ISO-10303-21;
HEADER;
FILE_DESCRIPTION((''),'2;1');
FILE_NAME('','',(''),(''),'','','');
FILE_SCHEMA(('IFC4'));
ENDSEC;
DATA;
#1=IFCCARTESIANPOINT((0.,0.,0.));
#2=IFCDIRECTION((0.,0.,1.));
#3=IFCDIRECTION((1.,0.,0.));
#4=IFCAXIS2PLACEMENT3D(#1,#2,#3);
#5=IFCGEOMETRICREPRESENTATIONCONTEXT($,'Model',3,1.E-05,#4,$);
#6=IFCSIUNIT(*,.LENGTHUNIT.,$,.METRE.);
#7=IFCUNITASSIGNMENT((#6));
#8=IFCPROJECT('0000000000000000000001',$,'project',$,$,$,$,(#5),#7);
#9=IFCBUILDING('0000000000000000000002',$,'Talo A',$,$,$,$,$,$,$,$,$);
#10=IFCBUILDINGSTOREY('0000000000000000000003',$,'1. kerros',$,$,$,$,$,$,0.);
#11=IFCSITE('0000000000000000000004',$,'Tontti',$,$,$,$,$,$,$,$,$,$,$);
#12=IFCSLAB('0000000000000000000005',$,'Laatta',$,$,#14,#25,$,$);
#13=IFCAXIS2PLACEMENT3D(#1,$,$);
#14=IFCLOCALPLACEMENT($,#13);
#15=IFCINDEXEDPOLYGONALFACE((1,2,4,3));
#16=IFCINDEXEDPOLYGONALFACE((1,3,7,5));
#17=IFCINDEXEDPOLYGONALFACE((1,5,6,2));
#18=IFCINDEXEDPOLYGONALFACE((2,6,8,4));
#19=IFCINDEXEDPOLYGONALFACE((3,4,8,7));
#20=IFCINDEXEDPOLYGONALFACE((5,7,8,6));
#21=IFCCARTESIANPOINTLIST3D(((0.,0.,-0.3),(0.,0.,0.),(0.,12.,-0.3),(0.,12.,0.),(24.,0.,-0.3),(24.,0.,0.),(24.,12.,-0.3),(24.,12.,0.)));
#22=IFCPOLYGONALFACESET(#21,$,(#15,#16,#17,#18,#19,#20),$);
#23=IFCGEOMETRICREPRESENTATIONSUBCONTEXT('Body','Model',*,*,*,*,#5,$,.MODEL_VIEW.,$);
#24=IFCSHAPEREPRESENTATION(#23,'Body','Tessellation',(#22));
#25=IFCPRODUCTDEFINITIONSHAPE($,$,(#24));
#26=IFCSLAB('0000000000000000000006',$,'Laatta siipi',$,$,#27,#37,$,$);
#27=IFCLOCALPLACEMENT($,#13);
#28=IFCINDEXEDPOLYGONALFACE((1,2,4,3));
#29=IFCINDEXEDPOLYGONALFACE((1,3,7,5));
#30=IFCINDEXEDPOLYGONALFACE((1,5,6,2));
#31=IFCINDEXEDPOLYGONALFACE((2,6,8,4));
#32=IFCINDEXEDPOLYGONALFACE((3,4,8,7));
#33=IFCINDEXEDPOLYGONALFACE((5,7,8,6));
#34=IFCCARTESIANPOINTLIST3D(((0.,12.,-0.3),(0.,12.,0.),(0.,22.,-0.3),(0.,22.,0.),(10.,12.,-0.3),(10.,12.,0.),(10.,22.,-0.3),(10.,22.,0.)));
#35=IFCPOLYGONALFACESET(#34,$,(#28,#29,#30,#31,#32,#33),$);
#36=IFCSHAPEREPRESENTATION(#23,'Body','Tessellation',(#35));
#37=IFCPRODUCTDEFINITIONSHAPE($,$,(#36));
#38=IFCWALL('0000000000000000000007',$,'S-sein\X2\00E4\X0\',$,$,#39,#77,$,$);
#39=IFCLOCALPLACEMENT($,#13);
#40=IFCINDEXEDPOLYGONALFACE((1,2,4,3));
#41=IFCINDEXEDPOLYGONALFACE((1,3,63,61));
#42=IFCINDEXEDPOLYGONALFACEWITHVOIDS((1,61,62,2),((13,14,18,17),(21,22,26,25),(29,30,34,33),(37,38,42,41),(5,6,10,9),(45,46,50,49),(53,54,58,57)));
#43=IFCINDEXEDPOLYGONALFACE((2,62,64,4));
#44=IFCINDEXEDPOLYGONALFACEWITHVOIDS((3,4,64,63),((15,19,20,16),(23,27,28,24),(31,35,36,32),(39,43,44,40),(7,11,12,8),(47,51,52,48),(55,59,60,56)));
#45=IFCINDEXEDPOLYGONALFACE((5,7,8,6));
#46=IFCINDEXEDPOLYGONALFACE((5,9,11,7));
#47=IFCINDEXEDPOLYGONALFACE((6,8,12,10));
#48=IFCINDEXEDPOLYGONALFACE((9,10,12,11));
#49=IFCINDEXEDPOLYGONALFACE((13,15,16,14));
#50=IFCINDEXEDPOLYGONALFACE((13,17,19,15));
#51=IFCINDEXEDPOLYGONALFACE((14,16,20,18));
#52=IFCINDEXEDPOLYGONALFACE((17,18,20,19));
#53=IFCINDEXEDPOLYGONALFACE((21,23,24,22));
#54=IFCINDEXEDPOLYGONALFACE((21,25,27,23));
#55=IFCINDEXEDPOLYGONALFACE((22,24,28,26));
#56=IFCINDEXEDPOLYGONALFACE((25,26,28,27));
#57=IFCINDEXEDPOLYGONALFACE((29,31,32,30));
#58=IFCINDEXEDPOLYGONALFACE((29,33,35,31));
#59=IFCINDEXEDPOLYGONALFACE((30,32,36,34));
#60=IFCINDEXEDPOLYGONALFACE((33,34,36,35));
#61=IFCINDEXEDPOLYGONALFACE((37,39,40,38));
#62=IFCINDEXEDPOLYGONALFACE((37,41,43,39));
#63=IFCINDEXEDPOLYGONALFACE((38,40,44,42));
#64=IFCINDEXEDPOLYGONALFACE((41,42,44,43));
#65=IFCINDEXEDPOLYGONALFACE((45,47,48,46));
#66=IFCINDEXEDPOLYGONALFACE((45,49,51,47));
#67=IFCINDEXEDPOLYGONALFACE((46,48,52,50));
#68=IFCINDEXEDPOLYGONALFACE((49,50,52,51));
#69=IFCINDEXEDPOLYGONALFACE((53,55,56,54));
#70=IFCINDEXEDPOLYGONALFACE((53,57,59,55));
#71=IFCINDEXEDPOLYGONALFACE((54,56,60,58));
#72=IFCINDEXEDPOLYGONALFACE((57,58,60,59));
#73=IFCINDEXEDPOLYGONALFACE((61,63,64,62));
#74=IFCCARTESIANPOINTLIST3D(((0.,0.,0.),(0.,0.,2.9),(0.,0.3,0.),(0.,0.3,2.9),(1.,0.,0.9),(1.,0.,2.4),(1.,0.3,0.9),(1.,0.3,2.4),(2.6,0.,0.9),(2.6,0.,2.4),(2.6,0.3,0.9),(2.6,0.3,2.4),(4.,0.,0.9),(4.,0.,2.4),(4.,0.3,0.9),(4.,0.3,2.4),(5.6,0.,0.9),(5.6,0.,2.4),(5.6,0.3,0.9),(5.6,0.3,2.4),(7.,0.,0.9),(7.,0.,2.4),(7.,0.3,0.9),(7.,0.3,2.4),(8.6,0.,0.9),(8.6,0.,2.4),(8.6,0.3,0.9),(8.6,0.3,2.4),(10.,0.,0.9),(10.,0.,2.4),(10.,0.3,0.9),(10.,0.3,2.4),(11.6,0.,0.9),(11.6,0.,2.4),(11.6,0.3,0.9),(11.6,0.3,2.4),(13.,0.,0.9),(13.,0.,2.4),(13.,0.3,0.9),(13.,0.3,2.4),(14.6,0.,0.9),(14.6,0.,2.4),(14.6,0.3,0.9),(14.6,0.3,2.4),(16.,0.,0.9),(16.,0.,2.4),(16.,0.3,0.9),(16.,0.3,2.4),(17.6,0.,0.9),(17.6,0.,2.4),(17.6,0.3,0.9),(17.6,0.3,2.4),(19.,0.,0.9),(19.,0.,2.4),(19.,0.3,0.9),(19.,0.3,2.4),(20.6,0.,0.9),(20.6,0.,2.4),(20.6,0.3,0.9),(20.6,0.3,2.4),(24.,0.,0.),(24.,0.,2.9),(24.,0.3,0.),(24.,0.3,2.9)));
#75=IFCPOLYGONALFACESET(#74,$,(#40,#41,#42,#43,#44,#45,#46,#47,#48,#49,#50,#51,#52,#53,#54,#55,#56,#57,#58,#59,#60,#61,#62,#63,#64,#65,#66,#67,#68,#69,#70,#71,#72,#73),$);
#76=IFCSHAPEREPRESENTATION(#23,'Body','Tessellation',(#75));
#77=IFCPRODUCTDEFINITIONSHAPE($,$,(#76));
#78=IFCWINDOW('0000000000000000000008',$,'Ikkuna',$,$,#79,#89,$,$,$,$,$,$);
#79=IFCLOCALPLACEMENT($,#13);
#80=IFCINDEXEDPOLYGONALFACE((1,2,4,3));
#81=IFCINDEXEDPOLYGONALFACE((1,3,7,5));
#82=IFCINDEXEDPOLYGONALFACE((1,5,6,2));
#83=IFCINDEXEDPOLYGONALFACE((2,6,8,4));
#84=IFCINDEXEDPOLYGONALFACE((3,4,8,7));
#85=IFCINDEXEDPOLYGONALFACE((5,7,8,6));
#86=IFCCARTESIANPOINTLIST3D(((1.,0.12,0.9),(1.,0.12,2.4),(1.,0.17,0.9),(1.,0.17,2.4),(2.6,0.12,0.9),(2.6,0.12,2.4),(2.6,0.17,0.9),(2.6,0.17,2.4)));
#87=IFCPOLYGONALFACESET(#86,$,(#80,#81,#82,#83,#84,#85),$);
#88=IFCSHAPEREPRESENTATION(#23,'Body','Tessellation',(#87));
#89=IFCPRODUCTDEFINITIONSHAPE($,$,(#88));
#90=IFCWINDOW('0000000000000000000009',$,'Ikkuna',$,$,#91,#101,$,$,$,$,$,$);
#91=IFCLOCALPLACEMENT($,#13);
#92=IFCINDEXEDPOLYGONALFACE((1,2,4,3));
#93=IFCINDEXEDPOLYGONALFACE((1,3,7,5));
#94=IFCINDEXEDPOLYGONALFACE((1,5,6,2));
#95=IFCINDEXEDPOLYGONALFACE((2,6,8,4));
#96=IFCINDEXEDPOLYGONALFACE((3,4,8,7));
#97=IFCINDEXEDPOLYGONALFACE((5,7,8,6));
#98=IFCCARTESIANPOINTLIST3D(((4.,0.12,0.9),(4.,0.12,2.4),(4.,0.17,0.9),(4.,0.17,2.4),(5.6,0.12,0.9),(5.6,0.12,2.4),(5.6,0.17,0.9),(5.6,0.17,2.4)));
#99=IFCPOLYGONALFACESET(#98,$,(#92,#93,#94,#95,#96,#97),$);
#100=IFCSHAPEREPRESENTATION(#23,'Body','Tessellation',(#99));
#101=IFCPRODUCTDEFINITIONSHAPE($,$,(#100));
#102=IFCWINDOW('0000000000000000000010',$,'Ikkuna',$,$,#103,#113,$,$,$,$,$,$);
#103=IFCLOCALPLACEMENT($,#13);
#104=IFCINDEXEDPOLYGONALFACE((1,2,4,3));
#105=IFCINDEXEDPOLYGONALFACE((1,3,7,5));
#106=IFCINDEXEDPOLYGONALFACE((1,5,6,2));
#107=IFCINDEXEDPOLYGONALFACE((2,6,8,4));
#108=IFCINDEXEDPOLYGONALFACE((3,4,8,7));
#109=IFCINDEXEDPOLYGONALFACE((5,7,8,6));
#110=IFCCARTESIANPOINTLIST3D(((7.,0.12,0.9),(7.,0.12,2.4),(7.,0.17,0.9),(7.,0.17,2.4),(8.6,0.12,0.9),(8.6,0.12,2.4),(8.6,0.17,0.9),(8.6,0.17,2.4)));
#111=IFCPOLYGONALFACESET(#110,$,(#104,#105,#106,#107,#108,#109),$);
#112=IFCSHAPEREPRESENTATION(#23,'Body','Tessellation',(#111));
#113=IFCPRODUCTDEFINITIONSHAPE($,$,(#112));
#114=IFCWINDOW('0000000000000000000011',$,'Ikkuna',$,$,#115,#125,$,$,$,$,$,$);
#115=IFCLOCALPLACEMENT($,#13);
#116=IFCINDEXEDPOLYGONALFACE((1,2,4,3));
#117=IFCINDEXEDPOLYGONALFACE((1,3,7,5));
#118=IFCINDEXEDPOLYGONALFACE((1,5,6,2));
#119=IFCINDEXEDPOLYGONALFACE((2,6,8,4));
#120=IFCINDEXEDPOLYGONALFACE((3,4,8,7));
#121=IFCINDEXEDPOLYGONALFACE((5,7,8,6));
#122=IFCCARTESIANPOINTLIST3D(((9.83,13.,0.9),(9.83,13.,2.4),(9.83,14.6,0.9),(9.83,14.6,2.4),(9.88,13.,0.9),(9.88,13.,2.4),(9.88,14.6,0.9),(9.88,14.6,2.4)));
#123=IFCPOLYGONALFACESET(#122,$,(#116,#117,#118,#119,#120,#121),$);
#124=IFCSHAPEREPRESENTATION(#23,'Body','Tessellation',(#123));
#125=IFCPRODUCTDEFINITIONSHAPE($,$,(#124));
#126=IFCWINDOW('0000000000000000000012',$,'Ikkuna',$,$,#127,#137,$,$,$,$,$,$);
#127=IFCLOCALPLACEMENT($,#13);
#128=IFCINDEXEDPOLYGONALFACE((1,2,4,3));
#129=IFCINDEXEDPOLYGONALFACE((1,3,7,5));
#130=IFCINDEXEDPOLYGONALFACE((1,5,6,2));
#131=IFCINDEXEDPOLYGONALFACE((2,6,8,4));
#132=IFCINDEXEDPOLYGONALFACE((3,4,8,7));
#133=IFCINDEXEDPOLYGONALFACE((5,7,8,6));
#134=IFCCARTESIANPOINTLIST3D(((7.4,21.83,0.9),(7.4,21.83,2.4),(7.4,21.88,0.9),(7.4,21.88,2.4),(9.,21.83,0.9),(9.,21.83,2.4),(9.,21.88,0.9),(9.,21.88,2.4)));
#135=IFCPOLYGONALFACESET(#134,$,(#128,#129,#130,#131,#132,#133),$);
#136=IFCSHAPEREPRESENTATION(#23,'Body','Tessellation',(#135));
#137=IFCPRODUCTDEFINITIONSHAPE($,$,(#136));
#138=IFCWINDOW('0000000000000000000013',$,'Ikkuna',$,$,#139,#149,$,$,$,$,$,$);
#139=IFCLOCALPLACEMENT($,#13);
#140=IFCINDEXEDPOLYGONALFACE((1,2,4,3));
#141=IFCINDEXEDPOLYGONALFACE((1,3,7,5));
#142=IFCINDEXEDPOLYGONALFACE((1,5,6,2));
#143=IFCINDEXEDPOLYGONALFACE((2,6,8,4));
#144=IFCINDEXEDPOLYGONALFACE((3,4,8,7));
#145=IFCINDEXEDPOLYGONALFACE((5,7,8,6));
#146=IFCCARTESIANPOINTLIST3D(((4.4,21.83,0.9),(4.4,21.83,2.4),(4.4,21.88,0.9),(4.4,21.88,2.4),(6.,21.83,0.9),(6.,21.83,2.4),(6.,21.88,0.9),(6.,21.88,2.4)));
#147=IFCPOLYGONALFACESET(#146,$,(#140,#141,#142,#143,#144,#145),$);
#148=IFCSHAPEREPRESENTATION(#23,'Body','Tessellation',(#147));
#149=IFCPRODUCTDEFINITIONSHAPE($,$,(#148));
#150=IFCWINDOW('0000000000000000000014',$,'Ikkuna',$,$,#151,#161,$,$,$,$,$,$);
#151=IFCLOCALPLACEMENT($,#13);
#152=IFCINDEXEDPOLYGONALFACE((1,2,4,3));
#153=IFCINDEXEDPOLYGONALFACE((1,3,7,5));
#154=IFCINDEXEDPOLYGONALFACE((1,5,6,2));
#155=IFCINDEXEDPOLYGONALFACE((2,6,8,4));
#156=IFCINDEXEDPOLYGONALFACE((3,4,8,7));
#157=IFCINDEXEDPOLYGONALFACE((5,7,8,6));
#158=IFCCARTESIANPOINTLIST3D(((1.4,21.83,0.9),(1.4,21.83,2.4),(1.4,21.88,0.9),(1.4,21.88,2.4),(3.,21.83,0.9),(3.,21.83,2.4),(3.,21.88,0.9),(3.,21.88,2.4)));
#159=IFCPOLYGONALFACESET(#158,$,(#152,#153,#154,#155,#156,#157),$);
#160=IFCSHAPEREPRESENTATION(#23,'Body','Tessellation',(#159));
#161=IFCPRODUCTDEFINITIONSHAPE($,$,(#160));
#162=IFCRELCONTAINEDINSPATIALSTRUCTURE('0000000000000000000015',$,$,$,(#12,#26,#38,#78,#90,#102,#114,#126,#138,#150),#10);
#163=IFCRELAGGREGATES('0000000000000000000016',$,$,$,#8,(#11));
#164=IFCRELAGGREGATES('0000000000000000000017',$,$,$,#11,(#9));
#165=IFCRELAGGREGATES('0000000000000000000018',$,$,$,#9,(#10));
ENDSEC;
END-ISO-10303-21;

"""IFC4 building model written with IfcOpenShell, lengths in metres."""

from ifc_helpers import new_model, si_unit, frame, origin_with_axes, place, context, subcontext, project, spatial, indexed_curve, outline, extrude, element, save


model = new_model("IFC4")

# Units and contexts
model_context = context("Model", 3, precision=1e-05, world=origin_with_axes())
body_context = subcontext(model_context, "Body", "Model", "MODEL_VIEW")
ifc_project = project(units=[si_unit("LENGTHUNIT", "METRE")], contexts=[model_context])

# Site, building, storey
site = spatial("IfcSite", under=ifc_project, Name="Tontti")
building = spatial("IfcBuilding", under=site, Name="Talo A")
storey = spatial("IfcBuildingStorey", under=building, Name="1. kerros", Elevation=0.0)

# Slabs
slab_1_placement = place(None, frame((0.0, 0.0, -0.3), z_axis=(0.0, 0.0, 1.0), x_axis=(1.0, 0.0, 0.0)))
element("IfcSlab", 1, at=slab_1_placement, inside=storey, Name="Laatta", context=body_context, shape_type="SweptSolid", body=[
    extrude(outline(indexed_curve([(0.0, 0.0), (0.0, 12.0), (24.0, 12.0), (24.0, 0.0), (0.0, 0.0)], self_intersect=False)), origin_with_axes(), (0.0, 0.0, 1.0), 0.3),
])
slab_2_placement = place(None, frame((0.0, 12.0, -0.3), z_axis=(0.0, 0.0, 1.0), x_axis=(1.0, 0.0, 0.0)))
element("IfcSlab", 2, at=slab_2_placement, inside=storey, Name="Laatta siipi", context=body_context, shape_type="SweptSolid", body=[
    extrude(outline(indexed_curve([(0.0, 0.0), (0.0, 10.0), (10.0, 10.0), (10.0, 0.0), (0.0, 0.0)], self_intersect=False)), origin_with_axes(), (0.0, 0.0, 1.0), 0.3),
])

# Wall, openings
wall_1_placement = place(None, origin_with_axes())
wall_1 = element("IfcWall", 3, at=wall_1_placement, inside=storey, Name="S-seinä", context=body_context, shape_type="SweptSolid", body=[
    extrude(outline(indexed_curve([(0.0, 0.0), (0.0, 0.3), (24.0, 0.3), (24.0, 0.0), (0.0, 0.0)], self_intersect=False)), origin_with_axes(), (0.0, 0.0, 1.0), 2.9),
])
opening_1_placement = place(wall_1_placement, frame((1.0, -0.1, 0.9), z_axis=(0.0, 0.0, 1.0), x_axis=(1.0, 0.0, 0.0)))
element("IfcOpeningElement", 4, at=opening_1_placement, cuts=wall_1, context=body_context, shape_type="SweptSolid", body=[
    extrude(outline(indexed_curve([(0.0, 0.0), (0.0, 0.5), (1.6, 0.5), (1.6, 0.0), (0.0, 0.0)], self_intersect=False)), origin_with_axes(), (0.0, 0.0, 1.0), 1.5),
])
opening_2_placement = place(wall_1_placement, frame((4.0, -0.1, 0.9), z_axis=(0.0, 0.0, 1.0), x_axis=(1.0, 0.0, 0.0)))
element("IfcOpeningElement", 5, at=opening_2_placement, cuts=wall_1, context=body_context, shape_type="SweptSolid", body=[
    extrude(outline(indexed_curve([(0.0, 0.0), (0.0, 0.5), (1.6, 0.5), (1.6, 0.0), (0.0, 0.0)], self_intersect=False)), origin_with_axes(), (0.0, 0.0, 1.0), 1.5),
])
opening_3_placement = place(wall_1_placement, frame((7.0, -0.1, 0.9), z_axis=(0.0, 0.0, 1.0), x_axis=(1.0, 0.0, 0.0)))
element("IfcOpeningElement", 6, at=opening_3_placement, cuts=wall_1, context=body_context, shape_type="SweptSolid", body=[
    extrude(outline(indexed_curve([(0.0, 0.0), (0.0, 0.5), (1.6, 0.5), (1.6, 0.0), (0.0, 0.0)], self_intersect=False)), origin_with_axes(), (0.0, 0.0, 1.0), 1.5),
])
opening_4_placement = place(wall_1_placement, frame((10.0, -0.1, 0.9), z_axis=(0.0, 0.0, 1.0), x_axis=(1.0, 0.0, 0.0)))
element("IfcOpeningElement", 7, at=opening_4_placement, cuts=wall_1, context=body_context, shape_type="SweptSolid", body=[
    extrude(outline(indexed_curve([(0.0, 0.0), (0.0, 0.5), (1.6, 0.5), (1.6, 0.0), (0.0, 0.0)], self_intersect=False)), origin_with_axes(), (0.0, 0.0, 1.0), 1.5),
])
opening_5_placement = place(wall_1_placement, frame((13.0, -0.1, 0.9), z_axis=(0.0, 0.0, 1.0), x_axis=(1.0, 0.0, 0.0)))
element("IfcOpeningElement", 8, at=opening_5_placement, cuts=wall_1, context=body_context, shape_type="SweptSolid", body=[
    extrude(outline(indexed_curve([(0.0, 0.0), (0.0, 0.5), (1.6, 0.5), (1.6, 0.0), (0.0, 0.0)], self_intersect=False)), origin_with_axes(), (0.0, 0.0, 1.0), 1.5),
])
opening_6_placement = place(wall_1_placement, frame((16.0, -0.1, 0.9), z_axis=(0.0, 0.0, 1.0), x_axis=(1.0, 0.0, 0.0)))
element("IfcOpeningElement", 9, at=opening_6_placement, cuts=wall_1, context=body_context, shape_type="SweptSolid", body=[
    extrude(outline(indexed_curve([(0.0, 0.0), (0.0, 0.5), (1.6, 0.5), (1.6, 0.0), (0.0, 0.0)], self_intersect=False)), origin_with_axes(), (0.0, 0.0, 1.0), 1.5),
])
opening_7_placement = place(wall_1_placement, frame((19.0, -0.1, 0.9), z_axis=(0.0, 0.0, 1.0), x_axis=(1.0, 0.0, 0.0)))
element("IfcOpeningElement", 10, at=opening_7_placement, cuts=wall_1, context=body_context, shape_type="SweptSolid", body=[
    extrude(outline(indexed_curve([(0.0, 0.0), (0.0, 0.5), (1.6, 0.5), (1.6, 0.0), (0.0, 0.0)], self_intersect=False)), origin_with_axes(), (0.0, 0.0, 1.0), 1.5),
])

# Windows
for number, where, z_axis, x_axis, name in (
    (11, (1.0, 0.12, 0.9), (0.0, 0.0, 1.0), (1.0, 0.0, 0.0), "Ikkuna"),
    (12, (4.0, 0.12, 0.9), (0.0, 0.0, 1.0), (1.0, 0.0, 0.0), "Ikkuna"),
    (13, (7.0, 0.12, 0.9), (0.0, 0.0, 1.0), (1.0, 0.0, 0.0), "Ikkuna"),
    (14, (9.88, 13.0, 0.9), (0.0, 0.0, 1.0), (0.0, 1.0, 0.0), "Ikkuna"),
    (15, (9.0, 21.88, 0.9), (0.0, 0.0, 1.0), (-1.0, 0.0, 0.0), "Ikkuna"),
    (16, (6.0, 21.88, 0.9), (0.0, 0.0, 1.0), (-1.0, 0.0, 0.0), "Ikkuna"),
    (17, (3.0, 21.88, 0.9), (0.0, 0.0, 1.0), (-1.0, 0.0, 0.0), "Ikkuna"),
):
    element("IfcWindow", number, at=place(None, frame(where, z_axis=z_axis, x_axis=x_axis)), inside=storey, Name=name, context=body_context, shape_type="SweptSolid", body=[
        extrude(outline(indexed_curve([(0.0, 0.0), (0.0, 0.05), (1.6, 0.05), (1.6, 0.0), (0.0, 0.0)], self_intersect=False)), origin_with_axes(), (0.0, 0.0, 1.0), 1.5),
    ])

save(model, "model.ifc")
